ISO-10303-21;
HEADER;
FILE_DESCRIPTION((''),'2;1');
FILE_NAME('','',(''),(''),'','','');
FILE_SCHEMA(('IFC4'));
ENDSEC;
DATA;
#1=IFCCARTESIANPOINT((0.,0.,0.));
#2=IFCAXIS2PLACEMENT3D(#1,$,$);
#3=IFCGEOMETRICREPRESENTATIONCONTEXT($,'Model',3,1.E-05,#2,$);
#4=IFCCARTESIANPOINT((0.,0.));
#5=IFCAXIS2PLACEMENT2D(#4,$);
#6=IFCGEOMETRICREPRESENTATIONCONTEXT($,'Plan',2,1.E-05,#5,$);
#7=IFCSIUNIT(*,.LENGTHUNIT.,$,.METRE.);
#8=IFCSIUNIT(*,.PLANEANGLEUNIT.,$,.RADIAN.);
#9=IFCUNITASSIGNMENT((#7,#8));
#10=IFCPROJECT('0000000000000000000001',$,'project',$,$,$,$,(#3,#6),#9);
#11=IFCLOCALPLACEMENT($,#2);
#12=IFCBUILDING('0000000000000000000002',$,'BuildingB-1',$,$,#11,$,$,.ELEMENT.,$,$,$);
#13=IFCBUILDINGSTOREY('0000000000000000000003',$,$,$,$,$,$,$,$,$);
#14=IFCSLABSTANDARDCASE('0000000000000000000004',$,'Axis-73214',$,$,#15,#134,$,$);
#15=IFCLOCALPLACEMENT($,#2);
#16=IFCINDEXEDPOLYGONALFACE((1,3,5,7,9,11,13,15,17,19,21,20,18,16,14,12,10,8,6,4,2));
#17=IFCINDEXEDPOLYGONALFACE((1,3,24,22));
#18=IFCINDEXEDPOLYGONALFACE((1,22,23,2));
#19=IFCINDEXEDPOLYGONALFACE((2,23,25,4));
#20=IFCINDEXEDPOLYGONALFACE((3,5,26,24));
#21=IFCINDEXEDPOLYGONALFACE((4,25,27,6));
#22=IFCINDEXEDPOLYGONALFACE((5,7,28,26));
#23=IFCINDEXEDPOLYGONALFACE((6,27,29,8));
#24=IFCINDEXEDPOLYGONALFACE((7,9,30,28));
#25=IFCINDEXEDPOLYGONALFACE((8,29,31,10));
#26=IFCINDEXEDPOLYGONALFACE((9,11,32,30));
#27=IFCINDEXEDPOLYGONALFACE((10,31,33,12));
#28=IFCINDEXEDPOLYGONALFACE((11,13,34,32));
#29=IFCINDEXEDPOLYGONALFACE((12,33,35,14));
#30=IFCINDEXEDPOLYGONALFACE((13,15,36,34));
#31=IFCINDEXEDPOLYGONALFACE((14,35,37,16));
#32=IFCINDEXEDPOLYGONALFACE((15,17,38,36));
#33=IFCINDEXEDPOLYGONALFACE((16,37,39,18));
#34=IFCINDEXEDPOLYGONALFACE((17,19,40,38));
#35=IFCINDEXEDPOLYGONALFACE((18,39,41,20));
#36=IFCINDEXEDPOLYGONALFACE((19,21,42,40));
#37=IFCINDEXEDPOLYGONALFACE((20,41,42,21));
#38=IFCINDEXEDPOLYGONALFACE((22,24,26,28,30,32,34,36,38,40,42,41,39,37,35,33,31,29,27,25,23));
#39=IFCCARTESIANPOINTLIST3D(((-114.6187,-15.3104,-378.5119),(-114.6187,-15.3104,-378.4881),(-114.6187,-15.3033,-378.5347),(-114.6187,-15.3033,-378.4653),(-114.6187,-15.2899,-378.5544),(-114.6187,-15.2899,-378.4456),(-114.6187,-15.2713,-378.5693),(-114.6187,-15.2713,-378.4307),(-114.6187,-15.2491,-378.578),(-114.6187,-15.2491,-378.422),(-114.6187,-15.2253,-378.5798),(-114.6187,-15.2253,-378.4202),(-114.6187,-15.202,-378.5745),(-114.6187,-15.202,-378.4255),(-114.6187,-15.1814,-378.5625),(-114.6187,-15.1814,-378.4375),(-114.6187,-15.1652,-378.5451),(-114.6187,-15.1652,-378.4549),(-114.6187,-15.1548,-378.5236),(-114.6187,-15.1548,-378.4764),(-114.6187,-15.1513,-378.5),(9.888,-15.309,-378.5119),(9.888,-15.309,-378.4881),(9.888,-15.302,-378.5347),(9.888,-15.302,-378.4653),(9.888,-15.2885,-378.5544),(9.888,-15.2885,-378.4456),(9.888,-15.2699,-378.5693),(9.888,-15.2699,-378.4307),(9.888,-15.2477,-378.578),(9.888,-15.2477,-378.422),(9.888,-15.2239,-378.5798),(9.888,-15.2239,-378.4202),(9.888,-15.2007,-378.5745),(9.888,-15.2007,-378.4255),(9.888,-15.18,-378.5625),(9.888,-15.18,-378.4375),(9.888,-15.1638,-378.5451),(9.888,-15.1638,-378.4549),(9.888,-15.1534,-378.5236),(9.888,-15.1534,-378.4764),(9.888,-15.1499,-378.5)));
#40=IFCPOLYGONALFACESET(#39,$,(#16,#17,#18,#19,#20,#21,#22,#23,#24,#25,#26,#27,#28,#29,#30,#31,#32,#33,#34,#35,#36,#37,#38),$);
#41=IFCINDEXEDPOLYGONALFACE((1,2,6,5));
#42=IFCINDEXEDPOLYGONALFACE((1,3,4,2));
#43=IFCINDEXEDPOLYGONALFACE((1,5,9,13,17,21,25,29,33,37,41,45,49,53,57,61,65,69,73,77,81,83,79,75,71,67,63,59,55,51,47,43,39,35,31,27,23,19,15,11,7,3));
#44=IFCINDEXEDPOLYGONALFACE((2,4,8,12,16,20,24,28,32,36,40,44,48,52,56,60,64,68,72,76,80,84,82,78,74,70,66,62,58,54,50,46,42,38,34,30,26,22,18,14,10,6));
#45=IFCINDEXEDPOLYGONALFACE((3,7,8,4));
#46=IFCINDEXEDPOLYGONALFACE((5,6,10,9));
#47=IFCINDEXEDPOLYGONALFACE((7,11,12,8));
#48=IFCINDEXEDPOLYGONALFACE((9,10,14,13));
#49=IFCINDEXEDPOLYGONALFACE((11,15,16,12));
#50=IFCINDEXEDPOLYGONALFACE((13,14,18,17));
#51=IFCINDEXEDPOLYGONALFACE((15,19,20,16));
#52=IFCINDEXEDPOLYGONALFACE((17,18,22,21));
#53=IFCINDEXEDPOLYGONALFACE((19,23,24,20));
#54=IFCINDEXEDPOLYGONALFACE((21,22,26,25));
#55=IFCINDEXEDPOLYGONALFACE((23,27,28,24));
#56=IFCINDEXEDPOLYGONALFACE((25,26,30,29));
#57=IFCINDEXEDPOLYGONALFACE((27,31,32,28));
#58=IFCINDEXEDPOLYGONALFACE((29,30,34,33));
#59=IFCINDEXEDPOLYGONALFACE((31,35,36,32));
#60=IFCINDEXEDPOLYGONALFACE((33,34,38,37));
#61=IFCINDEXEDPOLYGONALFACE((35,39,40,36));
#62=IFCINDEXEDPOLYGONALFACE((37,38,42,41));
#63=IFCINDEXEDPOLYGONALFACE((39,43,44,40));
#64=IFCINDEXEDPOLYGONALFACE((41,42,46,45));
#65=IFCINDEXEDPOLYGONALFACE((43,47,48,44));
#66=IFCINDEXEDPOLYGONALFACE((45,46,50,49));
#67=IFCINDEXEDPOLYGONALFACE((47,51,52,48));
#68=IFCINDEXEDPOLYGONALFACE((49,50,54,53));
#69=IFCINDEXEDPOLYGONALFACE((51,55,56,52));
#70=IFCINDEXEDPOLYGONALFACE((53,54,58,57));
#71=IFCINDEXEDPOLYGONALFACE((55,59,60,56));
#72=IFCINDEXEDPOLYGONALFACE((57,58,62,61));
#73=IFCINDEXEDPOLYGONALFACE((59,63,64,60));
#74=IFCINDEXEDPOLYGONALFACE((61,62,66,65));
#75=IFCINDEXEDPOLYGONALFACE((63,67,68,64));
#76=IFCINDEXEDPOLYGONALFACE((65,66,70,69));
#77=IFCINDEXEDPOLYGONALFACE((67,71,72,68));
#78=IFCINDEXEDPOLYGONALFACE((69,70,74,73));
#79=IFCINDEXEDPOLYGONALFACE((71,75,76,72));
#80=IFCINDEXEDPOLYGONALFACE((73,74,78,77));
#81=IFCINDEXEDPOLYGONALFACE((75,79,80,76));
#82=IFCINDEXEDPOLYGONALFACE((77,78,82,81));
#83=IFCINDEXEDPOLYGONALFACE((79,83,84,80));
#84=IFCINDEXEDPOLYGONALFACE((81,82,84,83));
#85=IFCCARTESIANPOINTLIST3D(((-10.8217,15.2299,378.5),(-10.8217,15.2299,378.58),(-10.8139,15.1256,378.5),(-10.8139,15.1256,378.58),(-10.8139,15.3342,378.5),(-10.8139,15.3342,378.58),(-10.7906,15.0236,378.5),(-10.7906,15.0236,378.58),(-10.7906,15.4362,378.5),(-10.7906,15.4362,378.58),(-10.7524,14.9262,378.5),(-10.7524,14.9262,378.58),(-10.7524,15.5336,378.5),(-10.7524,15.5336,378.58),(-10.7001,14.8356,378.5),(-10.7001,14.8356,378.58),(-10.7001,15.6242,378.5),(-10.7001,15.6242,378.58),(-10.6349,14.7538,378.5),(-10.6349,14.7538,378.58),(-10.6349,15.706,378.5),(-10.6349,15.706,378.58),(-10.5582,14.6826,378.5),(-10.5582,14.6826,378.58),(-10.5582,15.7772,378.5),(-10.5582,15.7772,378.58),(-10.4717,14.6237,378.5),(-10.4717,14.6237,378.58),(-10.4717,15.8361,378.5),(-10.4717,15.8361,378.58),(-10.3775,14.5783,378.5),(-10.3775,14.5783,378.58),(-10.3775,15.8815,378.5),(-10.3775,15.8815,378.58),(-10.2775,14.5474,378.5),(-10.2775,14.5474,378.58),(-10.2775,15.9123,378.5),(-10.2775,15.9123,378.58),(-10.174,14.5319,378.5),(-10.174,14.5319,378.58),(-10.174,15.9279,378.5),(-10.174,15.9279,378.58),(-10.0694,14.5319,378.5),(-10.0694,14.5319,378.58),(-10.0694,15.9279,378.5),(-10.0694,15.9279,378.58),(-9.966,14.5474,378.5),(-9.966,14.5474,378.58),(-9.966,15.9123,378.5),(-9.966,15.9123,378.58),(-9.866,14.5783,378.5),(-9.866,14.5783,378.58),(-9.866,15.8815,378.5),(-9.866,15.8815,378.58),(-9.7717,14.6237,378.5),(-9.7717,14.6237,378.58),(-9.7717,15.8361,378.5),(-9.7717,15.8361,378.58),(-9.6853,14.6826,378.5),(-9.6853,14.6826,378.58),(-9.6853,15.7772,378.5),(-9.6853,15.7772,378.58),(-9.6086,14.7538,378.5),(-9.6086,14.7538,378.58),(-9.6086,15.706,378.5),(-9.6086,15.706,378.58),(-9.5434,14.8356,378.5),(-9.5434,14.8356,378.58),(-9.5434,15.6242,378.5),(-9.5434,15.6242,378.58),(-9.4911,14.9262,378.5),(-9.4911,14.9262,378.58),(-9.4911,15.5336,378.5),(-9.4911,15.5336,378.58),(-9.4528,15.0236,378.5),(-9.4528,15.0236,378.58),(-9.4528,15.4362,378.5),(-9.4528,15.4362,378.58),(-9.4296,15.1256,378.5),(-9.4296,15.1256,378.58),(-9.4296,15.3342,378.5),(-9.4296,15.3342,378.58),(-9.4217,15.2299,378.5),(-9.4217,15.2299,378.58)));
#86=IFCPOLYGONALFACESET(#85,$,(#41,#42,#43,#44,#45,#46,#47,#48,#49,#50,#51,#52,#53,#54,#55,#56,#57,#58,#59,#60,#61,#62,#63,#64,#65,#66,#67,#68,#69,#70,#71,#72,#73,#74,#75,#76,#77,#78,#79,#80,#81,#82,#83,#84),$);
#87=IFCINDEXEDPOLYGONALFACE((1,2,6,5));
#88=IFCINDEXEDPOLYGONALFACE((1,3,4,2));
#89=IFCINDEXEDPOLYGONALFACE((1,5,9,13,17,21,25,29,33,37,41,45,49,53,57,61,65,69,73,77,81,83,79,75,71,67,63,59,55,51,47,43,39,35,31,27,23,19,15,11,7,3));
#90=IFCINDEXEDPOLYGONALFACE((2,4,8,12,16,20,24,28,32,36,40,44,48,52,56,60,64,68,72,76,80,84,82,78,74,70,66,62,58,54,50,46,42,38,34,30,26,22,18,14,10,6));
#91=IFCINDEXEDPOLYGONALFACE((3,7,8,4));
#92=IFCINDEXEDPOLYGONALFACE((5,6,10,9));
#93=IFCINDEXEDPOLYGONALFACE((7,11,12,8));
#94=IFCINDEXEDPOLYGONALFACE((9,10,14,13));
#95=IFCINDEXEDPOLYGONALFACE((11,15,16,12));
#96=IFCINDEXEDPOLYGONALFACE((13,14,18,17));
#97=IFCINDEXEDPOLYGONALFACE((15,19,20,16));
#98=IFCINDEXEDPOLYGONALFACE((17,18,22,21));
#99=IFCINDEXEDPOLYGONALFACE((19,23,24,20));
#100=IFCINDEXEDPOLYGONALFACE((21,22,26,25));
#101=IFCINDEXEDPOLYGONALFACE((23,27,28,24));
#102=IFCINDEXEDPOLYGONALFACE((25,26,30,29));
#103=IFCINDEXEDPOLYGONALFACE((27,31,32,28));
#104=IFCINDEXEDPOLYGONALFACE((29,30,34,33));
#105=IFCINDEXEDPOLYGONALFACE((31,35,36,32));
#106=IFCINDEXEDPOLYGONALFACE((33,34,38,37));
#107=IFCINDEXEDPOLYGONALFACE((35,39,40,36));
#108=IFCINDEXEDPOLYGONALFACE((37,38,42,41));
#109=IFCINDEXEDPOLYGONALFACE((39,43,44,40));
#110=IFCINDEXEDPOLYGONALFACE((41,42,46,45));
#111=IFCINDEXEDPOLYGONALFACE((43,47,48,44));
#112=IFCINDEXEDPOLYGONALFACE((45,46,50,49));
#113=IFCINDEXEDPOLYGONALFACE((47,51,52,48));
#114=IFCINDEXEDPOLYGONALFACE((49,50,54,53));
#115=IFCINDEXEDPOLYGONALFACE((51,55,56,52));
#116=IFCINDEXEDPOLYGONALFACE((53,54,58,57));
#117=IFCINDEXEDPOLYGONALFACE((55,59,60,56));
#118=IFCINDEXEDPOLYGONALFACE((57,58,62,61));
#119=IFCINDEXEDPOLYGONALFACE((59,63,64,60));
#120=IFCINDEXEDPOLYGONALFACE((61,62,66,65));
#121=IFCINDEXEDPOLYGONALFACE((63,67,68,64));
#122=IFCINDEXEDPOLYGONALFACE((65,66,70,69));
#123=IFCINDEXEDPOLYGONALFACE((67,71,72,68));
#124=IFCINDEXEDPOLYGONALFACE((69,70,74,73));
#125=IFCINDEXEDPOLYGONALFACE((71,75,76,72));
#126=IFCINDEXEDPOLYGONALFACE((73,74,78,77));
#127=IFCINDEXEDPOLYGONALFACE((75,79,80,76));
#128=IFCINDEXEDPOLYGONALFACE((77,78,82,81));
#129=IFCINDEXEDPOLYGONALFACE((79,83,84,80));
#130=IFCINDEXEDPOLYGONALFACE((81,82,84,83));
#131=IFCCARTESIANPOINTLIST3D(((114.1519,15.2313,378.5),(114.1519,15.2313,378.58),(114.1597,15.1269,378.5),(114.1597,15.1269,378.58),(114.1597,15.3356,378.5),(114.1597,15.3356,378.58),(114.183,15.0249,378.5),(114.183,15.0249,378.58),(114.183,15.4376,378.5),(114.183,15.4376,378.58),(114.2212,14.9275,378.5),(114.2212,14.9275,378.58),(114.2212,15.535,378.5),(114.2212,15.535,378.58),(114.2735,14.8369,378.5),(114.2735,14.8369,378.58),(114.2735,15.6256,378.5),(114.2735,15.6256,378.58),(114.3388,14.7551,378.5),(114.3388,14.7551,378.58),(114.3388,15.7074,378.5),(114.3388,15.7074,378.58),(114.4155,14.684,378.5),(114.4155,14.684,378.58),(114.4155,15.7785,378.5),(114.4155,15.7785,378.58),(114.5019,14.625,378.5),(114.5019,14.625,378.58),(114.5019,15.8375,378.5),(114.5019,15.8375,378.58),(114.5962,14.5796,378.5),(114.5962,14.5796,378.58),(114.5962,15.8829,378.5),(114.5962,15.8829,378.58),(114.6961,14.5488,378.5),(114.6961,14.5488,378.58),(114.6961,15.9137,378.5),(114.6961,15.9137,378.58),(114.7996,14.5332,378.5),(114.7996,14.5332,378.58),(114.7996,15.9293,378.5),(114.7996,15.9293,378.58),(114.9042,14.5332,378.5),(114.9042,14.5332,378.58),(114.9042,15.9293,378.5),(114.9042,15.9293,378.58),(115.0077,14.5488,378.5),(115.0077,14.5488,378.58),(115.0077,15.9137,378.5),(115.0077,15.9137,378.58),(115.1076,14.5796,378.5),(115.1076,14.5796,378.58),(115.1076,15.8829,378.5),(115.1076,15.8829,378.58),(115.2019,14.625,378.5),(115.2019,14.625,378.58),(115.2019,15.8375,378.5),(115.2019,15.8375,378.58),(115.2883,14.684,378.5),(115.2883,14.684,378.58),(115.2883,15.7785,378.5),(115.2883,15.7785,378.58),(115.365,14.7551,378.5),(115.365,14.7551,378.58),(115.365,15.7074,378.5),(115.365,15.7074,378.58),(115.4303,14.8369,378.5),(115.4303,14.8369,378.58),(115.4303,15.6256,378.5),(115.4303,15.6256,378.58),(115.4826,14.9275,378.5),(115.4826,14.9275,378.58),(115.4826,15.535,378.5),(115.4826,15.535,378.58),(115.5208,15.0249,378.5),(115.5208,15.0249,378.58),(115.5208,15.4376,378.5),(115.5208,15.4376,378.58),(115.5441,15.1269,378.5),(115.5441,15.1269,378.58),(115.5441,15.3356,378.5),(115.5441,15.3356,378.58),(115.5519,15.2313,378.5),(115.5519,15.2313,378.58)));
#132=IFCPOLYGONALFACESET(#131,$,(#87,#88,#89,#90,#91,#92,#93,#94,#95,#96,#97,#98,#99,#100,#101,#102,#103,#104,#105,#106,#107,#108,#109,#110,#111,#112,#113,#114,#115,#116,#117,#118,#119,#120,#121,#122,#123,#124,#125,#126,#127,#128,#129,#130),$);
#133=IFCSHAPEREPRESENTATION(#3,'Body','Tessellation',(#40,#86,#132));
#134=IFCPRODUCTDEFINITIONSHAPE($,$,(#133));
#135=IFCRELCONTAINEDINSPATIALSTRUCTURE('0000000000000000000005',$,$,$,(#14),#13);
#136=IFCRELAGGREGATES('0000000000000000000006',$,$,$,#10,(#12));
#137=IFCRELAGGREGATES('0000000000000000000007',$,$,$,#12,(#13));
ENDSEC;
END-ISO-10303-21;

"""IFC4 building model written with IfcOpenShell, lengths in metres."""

from ifc_helpers import new_model, entity, si_unit, frame, origin, origin_2d, place, context, project, spatial, circle, extrude, element, save


model = new_model("IFC4")

# Units and contexts
model_context = context("Model", 3, precision=1e-05, world=origin())
plan_context = context("Plan", 2, precision=1e-05, world=origin_2d())
ifc_project = project(units=[si_unit("LENGTHUNIT", "METRE"), si_unit("PLANEANGLEUNIT", "RADIAN")], contexts=[model_context, plan_context])

# Building, storey
building_placement = place(None, origin())
building = spatial("IfcBuilding", under=ifc_project, at=building_placement, Name="BuildingB-1", CompositionType="ELEMENT")
storey = spatial("IfcBuildingStorey", under=building)

# Slab
element("IfcSlabStandardCase", 1, inside=storey, Name="Axis-73214", context=model_context, shape_type="AdvancedSweptSolid", body=[
    entity("IfcSurfaceCurveSweptAreaSolid", entity("IfcCircleProfileDef", "AREA", None, None, 0.08), None, entity("IfcPolyline", [entity("IfcCartesianPoint", [-9.888, 15.2299, 378.5]), entity("IfcCartesianPoint", [114.6187, 15.2313, 378.5])]), None, None, entity("IfcPlane", entity("IfcAxis2Placement3D", entity("IfcCartesianPoint", [-9.888, 15.2299, 378.5]), entity("IfcDirection", [0.0, 0.0, 1.0]), entity("IfcDirection", [1.0, 0.0, 0.0])))),
    extrude(circle(Radius=0.7), frame((-10.1217, 15.2299, 378.5)), (0.0, 0.0, 1.0), 0.08),
    extrude(circle(Radius=0.7), frame((114.8519, 15.2313, 378.5)), (0.0, 0.0, 1.0), 0.08),
])

save(model, "model.ifc")
